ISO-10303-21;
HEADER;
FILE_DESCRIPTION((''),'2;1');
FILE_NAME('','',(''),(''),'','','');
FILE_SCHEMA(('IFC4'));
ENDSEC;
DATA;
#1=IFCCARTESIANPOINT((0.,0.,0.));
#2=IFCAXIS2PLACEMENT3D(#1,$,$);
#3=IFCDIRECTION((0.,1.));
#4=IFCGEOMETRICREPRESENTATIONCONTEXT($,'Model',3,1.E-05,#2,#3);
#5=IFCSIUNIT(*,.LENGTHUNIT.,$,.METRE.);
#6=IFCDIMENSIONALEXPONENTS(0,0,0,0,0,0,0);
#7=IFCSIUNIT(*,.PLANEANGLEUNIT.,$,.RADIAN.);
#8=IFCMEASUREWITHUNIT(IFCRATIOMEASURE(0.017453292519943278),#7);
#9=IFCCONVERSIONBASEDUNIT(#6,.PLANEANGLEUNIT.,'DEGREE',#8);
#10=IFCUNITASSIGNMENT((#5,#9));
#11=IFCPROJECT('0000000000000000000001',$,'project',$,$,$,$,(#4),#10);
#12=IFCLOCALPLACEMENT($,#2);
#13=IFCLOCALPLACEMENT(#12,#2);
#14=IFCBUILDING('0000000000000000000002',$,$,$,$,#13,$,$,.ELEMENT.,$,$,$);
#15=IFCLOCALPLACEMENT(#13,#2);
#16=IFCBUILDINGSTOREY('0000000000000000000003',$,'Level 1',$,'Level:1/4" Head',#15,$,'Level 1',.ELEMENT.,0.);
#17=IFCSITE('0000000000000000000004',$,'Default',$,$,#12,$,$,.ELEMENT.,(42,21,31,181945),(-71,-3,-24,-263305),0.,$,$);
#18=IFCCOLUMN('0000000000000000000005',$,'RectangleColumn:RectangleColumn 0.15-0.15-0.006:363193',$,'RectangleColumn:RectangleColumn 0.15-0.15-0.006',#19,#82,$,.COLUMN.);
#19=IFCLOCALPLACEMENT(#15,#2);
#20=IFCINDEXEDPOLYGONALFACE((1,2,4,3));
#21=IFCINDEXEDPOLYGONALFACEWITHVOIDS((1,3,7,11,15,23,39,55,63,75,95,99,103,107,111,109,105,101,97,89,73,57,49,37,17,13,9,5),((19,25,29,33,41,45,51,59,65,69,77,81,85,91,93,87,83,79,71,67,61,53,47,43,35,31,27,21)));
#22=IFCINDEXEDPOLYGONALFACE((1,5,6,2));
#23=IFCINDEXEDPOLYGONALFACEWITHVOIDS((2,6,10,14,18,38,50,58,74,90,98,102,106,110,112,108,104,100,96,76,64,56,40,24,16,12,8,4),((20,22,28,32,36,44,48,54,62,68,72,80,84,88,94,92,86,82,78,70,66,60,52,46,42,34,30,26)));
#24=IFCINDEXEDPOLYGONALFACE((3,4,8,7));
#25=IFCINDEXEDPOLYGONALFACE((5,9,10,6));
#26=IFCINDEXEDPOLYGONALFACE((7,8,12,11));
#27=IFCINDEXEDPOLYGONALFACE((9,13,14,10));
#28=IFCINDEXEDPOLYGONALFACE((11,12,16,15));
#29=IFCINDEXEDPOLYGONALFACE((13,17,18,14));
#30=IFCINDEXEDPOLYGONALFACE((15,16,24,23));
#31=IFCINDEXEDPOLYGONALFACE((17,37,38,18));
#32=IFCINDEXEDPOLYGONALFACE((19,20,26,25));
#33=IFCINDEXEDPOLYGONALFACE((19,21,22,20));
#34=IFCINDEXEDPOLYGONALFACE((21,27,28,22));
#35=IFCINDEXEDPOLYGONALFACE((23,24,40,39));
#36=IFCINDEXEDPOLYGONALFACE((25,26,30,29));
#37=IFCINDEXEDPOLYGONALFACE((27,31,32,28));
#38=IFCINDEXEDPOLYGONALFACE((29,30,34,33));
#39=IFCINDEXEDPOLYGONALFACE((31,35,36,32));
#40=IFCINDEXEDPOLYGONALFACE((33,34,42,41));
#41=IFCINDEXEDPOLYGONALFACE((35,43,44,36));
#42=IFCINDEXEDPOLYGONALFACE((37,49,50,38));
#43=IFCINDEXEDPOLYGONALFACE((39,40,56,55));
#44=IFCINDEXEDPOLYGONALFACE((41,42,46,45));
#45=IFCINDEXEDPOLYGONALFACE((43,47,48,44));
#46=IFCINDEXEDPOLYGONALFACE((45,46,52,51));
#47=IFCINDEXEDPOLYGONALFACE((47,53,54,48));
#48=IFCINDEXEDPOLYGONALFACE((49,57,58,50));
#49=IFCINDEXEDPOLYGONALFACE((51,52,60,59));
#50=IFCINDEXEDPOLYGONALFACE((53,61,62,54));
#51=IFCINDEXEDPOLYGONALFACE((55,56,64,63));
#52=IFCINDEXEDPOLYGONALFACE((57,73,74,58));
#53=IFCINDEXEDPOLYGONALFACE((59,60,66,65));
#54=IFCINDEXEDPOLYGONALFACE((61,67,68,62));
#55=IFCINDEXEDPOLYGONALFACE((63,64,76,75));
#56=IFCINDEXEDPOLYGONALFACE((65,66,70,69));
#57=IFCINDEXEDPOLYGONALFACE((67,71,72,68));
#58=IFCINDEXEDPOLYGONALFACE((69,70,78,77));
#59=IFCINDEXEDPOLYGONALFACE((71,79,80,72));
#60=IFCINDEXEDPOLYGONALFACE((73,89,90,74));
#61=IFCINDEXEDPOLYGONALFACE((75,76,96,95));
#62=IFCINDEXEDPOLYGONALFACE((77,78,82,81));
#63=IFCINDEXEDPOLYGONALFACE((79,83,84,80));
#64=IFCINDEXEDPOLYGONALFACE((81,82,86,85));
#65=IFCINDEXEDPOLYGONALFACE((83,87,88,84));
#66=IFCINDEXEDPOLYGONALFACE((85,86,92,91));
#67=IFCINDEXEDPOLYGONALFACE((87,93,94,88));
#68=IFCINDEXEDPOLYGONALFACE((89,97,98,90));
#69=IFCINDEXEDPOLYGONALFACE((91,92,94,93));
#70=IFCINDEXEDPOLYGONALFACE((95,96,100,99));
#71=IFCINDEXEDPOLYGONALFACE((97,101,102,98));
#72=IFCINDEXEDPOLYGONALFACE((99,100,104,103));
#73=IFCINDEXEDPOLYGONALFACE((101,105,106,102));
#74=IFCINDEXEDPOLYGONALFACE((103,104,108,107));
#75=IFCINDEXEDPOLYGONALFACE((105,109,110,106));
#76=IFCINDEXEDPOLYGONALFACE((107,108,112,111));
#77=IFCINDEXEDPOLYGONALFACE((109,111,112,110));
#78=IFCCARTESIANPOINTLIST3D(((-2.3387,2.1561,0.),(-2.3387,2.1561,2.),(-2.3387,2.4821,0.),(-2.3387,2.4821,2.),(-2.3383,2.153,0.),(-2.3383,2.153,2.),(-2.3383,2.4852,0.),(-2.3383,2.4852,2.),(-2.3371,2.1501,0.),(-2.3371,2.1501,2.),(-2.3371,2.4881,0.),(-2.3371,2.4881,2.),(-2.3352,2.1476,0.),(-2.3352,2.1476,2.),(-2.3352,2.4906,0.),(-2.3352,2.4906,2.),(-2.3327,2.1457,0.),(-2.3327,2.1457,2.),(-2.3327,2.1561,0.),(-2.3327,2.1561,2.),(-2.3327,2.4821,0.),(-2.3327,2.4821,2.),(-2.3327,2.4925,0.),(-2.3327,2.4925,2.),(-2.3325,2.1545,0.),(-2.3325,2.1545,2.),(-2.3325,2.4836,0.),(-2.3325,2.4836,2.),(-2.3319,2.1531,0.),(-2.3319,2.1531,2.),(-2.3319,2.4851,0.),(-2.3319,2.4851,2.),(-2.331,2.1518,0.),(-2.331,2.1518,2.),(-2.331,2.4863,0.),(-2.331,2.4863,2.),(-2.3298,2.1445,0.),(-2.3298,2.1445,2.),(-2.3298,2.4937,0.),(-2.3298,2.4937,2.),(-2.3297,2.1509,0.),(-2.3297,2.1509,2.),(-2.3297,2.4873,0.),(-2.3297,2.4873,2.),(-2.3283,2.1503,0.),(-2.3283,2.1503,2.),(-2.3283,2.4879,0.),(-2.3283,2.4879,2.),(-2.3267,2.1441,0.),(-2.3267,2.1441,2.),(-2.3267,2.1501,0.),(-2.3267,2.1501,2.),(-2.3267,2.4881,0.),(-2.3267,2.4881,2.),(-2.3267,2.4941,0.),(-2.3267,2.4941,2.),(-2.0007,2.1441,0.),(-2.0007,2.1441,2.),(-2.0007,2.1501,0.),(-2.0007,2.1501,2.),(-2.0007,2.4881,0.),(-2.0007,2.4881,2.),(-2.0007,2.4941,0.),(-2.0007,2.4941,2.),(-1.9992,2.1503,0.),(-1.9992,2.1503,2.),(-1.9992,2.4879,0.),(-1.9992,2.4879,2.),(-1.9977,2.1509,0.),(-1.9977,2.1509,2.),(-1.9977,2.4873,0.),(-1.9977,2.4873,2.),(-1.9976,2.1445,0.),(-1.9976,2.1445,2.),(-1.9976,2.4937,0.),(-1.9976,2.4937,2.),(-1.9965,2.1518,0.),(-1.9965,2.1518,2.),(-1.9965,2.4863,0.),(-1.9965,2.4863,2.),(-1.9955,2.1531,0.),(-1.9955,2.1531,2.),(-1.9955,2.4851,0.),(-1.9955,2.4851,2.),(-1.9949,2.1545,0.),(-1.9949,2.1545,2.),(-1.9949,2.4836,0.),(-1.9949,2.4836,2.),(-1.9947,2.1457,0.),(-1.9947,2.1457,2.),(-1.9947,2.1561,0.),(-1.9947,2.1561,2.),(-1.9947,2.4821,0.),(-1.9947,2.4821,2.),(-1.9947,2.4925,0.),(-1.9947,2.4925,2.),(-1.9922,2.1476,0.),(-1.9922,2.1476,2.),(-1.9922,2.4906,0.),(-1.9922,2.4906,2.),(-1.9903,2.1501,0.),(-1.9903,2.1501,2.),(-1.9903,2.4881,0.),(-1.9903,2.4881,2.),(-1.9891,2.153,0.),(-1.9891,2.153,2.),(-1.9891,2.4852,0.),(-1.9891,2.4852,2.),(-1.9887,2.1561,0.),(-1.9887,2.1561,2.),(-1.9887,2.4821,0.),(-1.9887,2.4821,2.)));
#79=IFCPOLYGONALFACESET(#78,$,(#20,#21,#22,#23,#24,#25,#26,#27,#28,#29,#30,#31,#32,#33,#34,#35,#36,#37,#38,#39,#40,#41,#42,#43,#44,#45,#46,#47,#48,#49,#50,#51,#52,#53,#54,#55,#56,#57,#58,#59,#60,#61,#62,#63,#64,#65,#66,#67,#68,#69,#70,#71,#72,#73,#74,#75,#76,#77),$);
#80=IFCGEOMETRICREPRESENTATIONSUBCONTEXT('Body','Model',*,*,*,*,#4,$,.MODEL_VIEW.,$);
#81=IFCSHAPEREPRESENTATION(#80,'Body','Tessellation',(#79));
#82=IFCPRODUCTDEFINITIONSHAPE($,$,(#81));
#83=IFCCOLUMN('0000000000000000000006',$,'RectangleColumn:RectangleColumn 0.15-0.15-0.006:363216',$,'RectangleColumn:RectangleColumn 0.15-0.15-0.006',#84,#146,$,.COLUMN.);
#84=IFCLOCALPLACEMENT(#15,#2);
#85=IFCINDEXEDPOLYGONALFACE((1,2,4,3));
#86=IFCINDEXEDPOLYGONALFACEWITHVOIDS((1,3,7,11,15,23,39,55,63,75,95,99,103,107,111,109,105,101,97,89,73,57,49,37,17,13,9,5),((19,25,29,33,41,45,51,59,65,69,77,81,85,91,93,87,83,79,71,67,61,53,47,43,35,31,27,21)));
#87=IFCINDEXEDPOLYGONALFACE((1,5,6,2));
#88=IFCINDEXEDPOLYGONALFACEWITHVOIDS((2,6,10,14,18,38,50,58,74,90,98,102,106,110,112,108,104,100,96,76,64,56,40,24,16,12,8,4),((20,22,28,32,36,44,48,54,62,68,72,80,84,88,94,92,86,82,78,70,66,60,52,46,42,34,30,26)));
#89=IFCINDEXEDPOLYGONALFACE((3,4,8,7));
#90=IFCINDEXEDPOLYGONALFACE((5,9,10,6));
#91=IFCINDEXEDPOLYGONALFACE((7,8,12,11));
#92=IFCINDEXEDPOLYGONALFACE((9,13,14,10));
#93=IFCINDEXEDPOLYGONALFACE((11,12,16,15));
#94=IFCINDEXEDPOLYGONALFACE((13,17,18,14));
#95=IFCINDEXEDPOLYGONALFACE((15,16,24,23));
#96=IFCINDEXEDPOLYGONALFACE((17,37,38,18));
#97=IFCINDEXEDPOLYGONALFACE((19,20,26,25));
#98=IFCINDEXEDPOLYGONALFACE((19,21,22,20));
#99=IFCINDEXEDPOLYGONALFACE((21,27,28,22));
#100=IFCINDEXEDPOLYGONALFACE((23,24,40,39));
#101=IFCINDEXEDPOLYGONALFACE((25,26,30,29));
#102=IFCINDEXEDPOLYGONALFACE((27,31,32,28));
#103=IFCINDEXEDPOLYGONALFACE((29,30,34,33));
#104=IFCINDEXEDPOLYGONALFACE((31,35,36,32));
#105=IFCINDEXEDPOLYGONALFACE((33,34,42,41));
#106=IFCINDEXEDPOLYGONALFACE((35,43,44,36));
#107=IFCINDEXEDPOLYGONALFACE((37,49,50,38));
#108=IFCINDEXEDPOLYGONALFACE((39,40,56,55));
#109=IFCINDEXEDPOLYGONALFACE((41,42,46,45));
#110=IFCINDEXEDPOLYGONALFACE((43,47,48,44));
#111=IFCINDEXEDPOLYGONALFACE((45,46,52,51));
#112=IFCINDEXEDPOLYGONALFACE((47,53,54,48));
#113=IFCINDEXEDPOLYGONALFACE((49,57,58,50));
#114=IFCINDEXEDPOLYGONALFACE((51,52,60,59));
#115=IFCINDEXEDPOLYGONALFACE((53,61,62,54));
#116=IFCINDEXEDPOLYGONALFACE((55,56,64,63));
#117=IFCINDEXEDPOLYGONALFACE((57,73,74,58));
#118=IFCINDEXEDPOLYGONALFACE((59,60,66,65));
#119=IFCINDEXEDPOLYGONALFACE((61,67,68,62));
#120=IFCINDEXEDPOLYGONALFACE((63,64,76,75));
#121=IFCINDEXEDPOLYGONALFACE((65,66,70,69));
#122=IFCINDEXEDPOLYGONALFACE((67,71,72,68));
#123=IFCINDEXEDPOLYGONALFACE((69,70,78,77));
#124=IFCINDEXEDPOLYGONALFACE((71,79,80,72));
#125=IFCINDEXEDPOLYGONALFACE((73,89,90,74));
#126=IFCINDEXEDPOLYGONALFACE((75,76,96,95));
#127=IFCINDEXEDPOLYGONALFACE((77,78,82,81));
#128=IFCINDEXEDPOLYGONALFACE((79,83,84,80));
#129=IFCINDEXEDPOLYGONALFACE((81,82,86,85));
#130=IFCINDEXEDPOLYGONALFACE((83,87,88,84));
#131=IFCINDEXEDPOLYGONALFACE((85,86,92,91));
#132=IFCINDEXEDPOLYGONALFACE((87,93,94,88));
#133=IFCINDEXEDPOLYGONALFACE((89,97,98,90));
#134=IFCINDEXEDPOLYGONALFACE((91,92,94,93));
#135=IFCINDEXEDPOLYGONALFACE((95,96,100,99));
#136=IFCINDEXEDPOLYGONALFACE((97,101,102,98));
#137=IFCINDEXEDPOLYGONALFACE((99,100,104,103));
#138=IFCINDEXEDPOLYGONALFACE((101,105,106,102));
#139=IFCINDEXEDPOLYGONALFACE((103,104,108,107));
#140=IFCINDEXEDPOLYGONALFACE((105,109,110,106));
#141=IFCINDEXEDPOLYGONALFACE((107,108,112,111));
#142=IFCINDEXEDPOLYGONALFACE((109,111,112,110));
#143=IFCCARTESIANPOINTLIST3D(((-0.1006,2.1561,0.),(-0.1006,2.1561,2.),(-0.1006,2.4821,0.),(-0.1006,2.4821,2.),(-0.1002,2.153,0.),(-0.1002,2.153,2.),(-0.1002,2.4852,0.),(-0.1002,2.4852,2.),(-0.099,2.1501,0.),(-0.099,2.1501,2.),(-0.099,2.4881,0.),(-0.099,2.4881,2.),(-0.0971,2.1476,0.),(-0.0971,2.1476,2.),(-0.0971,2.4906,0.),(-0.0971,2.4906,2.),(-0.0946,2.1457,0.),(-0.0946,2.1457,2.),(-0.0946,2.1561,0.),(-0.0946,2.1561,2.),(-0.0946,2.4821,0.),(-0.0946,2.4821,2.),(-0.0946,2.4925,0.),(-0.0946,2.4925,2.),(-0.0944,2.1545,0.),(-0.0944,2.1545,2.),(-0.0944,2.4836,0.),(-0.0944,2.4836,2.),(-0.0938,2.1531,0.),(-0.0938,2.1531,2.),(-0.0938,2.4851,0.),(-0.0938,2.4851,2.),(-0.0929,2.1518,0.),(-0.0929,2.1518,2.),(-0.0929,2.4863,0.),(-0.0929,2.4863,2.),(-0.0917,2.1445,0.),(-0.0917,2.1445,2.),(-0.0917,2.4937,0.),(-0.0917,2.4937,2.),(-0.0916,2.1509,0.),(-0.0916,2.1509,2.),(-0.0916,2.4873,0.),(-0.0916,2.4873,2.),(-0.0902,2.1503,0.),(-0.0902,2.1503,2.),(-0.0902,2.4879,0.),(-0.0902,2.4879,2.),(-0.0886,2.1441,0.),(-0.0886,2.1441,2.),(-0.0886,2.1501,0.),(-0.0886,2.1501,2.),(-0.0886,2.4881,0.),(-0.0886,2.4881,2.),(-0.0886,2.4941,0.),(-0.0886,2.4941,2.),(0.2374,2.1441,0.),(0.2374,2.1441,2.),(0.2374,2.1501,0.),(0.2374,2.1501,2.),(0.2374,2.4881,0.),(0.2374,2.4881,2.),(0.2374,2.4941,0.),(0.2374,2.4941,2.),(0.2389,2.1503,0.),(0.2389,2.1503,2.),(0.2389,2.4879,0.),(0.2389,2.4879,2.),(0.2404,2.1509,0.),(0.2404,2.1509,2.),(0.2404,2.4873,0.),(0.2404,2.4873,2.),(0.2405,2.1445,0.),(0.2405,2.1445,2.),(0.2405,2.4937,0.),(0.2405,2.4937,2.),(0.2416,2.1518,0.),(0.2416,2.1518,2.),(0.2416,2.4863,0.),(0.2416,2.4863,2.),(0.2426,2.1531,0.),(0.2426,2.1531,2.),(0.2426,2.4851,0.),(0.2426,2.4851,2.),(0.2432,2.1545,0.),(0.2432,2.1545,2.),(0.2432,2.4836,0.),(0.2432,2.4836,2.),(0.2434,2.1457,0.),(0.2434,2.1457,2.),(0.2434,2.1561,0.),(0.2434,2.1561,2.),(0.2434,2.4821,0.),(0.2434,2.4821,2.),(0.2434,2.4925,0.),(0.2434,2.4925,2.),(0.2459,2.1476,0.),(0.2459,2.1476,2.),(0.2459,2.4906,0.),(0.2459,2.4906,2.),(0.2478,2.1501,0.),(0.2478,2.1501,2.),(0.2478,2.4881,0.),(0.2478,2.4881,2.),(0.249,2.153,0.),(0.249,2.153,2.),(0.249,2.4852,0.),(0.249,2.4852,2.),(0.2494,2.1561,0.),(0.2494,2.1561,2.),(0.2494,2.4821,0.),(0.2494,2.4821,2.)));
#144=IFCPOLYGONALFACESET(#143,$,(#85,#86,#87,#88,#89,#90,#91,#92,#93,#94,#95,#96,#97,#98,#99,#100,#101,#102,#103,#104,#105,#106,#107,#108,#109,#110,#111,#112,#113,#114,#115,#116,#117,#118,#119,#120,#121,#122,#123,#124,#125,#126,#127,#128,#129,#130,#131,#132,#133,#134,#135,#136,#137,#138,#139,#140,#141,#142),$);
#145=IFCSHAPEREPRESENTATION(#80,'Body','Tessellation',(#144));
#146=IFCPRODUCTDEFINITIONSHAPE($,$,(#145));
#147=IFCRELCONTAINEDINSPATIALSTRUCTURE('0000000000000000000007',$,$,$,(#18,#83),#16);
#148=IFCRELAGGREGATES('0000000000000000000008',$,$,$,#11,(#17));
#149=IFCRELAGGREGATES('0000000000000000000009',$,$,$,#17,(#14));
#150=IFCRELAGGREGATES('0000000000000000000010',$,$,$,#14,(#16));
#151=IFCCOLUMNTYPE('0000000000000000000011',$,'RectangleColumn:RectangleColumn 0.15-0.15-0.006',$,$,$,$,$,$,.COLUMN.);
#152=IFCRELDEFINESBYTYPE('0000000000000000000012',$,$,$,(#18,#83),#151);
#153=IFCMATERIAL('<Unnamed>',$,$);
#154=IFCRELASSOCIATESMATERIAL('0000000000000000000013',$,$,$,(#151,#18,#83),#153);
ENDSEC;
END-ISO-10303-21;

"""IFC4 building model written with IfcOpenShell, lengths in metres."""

from ifc_helpers import new_model, entity, si_unit, converted_unit, direction, frame, origin, place, context, subcontext, project, spatial, line, arc, indexed_curve, outline, extrude, source, transform, mapped, material, type_object, type_shapes, element, save


model = new_model("IFC4")

# Units and contexts
model_context = context("Model", 3, precision=1e-05, world=origin(), true_north=direction((0.0, 1.0)))
body_context = subcontext(model_context, "Body", "Model", "MODEL_VIEW")
ifc_project = project(units=[si_unit("LENGTHUNIT", "METRE"), converted_unit("PLANEANGLEUNIT", "DEGREE", entity("IfcRatioMeasure", 0.017453292519943278), si_unit("PLANEANGLEUNIT", "RADIAN"), dimensions=[0, 0, 0, 0, 0, 0, 0])], contexts=[model_context])

# Site, building, storey
site_placement = place(None, origin())
site = spatial("IfcSite", under=ifc_project, at=site_placement, Name="Default", CompositionType="ELEMENT", RefLatitude=(42, 21, 31, 181945), RefLongitude=(-71, -3, -24, -263305), RefElevation=0.0)
building_placement = place(site_placement, origin())
building = spatial("IfcBuilding", under=site, at=building_placement, CompositionType="ELEMENT")
storey_placement = place(building_placement, origin())
storey = spatial("IfcBuildingStorey", under=building, at=storey_placement, Name="Level 1", ObjectType="Level:1/4\" Head", LongName="Level 1", CompositionType="ELEMENT", Elevation=0.0)

# Columns
ifc_material_1 = material(Name="<Unnamed>")
column_type = type_object("IfcColumnType", Name="RectangleColumn:RectangleColumn 0.15-0.15-0.006", PredefinedType="COLUMN", material=ifc_material_1)
shared_shape = source(origin(), body_context, "Body", "SweptSolid", [
    extrude(outline(indexed_curve([(-0.163, -0.175), (0.163, -0.175), (0.1715, -0.1715), (0.175, -0.163), (0.175, 0.163), (0.1715, 0.1715), (0.163, 0.175), (-0.163, 0.175), (-0.1715, 0.1715), (-0.175, 0.163), (-0.175, -0.163), (-0.1715, -0.1715)], segments=[line(1, 2), arc(2, 3, 4), line(4, 5), arc(5, 6, 7), line(7, 8), arc(8, 9, 10), line(10, 11), arc(11, 12, 1)], self_intersect=False), holes=[indexed_curve([(-0.163, -0.169), (-0.1672, -0.1672), (-0.169, -0.163), (-0.169, 0.163), (-0.1672, 0.1672), (-0.163, 0.169), (0.163, 0.169), (0.1672, 0.1672), (0.169, 0.163), (0.169, -0.163), (0.1672, -0.1672), (0.163, -0.169)], segments=[arc(1, 2, 3), line(3, 4), arc(4, 5, 6), line(6, 7), arc(7, 8, 9), line(9, 10), arc(10, 11, 12), line(12, 1)], self_intersect=False)]), frame((0.0, 0.0, 0.0), z_axis=(0.0, 0.0, 1.0), x_axis=(-1.0, 0.0, 0.0)), (0.0, 0.0, 1.0), 2.0),
])
type_shapes(column_type, [shared_shape])
for number, where, name in (
    (1, (-2.1637, 2.3191, 0.0), "RectangleColumn:RectangleColumn 0.15-0.15-0.006:363193"),
    (2, (0.0744, 2.3191, 0.0), "RectangleColumn:RectangleColumn 0.15-0.15-0.006:363216"),
):
    element("IfcColumn", number, at=place(storey_placement, frame(where)), inside=storey, type_object=column_type, material=ifc_material_1, Name=name, ObjectType="RectangleColumn:RectangleColumn 0.15-0.15-0.006", PredefinedType="COLUMN", context=body_context, shape_type="MappedRepresentation", body=[
        mapped(shared_shape, transform((0.0, 0.0, 0.0), scale=1.0)),
    ])

save(model, "model.ifc")
